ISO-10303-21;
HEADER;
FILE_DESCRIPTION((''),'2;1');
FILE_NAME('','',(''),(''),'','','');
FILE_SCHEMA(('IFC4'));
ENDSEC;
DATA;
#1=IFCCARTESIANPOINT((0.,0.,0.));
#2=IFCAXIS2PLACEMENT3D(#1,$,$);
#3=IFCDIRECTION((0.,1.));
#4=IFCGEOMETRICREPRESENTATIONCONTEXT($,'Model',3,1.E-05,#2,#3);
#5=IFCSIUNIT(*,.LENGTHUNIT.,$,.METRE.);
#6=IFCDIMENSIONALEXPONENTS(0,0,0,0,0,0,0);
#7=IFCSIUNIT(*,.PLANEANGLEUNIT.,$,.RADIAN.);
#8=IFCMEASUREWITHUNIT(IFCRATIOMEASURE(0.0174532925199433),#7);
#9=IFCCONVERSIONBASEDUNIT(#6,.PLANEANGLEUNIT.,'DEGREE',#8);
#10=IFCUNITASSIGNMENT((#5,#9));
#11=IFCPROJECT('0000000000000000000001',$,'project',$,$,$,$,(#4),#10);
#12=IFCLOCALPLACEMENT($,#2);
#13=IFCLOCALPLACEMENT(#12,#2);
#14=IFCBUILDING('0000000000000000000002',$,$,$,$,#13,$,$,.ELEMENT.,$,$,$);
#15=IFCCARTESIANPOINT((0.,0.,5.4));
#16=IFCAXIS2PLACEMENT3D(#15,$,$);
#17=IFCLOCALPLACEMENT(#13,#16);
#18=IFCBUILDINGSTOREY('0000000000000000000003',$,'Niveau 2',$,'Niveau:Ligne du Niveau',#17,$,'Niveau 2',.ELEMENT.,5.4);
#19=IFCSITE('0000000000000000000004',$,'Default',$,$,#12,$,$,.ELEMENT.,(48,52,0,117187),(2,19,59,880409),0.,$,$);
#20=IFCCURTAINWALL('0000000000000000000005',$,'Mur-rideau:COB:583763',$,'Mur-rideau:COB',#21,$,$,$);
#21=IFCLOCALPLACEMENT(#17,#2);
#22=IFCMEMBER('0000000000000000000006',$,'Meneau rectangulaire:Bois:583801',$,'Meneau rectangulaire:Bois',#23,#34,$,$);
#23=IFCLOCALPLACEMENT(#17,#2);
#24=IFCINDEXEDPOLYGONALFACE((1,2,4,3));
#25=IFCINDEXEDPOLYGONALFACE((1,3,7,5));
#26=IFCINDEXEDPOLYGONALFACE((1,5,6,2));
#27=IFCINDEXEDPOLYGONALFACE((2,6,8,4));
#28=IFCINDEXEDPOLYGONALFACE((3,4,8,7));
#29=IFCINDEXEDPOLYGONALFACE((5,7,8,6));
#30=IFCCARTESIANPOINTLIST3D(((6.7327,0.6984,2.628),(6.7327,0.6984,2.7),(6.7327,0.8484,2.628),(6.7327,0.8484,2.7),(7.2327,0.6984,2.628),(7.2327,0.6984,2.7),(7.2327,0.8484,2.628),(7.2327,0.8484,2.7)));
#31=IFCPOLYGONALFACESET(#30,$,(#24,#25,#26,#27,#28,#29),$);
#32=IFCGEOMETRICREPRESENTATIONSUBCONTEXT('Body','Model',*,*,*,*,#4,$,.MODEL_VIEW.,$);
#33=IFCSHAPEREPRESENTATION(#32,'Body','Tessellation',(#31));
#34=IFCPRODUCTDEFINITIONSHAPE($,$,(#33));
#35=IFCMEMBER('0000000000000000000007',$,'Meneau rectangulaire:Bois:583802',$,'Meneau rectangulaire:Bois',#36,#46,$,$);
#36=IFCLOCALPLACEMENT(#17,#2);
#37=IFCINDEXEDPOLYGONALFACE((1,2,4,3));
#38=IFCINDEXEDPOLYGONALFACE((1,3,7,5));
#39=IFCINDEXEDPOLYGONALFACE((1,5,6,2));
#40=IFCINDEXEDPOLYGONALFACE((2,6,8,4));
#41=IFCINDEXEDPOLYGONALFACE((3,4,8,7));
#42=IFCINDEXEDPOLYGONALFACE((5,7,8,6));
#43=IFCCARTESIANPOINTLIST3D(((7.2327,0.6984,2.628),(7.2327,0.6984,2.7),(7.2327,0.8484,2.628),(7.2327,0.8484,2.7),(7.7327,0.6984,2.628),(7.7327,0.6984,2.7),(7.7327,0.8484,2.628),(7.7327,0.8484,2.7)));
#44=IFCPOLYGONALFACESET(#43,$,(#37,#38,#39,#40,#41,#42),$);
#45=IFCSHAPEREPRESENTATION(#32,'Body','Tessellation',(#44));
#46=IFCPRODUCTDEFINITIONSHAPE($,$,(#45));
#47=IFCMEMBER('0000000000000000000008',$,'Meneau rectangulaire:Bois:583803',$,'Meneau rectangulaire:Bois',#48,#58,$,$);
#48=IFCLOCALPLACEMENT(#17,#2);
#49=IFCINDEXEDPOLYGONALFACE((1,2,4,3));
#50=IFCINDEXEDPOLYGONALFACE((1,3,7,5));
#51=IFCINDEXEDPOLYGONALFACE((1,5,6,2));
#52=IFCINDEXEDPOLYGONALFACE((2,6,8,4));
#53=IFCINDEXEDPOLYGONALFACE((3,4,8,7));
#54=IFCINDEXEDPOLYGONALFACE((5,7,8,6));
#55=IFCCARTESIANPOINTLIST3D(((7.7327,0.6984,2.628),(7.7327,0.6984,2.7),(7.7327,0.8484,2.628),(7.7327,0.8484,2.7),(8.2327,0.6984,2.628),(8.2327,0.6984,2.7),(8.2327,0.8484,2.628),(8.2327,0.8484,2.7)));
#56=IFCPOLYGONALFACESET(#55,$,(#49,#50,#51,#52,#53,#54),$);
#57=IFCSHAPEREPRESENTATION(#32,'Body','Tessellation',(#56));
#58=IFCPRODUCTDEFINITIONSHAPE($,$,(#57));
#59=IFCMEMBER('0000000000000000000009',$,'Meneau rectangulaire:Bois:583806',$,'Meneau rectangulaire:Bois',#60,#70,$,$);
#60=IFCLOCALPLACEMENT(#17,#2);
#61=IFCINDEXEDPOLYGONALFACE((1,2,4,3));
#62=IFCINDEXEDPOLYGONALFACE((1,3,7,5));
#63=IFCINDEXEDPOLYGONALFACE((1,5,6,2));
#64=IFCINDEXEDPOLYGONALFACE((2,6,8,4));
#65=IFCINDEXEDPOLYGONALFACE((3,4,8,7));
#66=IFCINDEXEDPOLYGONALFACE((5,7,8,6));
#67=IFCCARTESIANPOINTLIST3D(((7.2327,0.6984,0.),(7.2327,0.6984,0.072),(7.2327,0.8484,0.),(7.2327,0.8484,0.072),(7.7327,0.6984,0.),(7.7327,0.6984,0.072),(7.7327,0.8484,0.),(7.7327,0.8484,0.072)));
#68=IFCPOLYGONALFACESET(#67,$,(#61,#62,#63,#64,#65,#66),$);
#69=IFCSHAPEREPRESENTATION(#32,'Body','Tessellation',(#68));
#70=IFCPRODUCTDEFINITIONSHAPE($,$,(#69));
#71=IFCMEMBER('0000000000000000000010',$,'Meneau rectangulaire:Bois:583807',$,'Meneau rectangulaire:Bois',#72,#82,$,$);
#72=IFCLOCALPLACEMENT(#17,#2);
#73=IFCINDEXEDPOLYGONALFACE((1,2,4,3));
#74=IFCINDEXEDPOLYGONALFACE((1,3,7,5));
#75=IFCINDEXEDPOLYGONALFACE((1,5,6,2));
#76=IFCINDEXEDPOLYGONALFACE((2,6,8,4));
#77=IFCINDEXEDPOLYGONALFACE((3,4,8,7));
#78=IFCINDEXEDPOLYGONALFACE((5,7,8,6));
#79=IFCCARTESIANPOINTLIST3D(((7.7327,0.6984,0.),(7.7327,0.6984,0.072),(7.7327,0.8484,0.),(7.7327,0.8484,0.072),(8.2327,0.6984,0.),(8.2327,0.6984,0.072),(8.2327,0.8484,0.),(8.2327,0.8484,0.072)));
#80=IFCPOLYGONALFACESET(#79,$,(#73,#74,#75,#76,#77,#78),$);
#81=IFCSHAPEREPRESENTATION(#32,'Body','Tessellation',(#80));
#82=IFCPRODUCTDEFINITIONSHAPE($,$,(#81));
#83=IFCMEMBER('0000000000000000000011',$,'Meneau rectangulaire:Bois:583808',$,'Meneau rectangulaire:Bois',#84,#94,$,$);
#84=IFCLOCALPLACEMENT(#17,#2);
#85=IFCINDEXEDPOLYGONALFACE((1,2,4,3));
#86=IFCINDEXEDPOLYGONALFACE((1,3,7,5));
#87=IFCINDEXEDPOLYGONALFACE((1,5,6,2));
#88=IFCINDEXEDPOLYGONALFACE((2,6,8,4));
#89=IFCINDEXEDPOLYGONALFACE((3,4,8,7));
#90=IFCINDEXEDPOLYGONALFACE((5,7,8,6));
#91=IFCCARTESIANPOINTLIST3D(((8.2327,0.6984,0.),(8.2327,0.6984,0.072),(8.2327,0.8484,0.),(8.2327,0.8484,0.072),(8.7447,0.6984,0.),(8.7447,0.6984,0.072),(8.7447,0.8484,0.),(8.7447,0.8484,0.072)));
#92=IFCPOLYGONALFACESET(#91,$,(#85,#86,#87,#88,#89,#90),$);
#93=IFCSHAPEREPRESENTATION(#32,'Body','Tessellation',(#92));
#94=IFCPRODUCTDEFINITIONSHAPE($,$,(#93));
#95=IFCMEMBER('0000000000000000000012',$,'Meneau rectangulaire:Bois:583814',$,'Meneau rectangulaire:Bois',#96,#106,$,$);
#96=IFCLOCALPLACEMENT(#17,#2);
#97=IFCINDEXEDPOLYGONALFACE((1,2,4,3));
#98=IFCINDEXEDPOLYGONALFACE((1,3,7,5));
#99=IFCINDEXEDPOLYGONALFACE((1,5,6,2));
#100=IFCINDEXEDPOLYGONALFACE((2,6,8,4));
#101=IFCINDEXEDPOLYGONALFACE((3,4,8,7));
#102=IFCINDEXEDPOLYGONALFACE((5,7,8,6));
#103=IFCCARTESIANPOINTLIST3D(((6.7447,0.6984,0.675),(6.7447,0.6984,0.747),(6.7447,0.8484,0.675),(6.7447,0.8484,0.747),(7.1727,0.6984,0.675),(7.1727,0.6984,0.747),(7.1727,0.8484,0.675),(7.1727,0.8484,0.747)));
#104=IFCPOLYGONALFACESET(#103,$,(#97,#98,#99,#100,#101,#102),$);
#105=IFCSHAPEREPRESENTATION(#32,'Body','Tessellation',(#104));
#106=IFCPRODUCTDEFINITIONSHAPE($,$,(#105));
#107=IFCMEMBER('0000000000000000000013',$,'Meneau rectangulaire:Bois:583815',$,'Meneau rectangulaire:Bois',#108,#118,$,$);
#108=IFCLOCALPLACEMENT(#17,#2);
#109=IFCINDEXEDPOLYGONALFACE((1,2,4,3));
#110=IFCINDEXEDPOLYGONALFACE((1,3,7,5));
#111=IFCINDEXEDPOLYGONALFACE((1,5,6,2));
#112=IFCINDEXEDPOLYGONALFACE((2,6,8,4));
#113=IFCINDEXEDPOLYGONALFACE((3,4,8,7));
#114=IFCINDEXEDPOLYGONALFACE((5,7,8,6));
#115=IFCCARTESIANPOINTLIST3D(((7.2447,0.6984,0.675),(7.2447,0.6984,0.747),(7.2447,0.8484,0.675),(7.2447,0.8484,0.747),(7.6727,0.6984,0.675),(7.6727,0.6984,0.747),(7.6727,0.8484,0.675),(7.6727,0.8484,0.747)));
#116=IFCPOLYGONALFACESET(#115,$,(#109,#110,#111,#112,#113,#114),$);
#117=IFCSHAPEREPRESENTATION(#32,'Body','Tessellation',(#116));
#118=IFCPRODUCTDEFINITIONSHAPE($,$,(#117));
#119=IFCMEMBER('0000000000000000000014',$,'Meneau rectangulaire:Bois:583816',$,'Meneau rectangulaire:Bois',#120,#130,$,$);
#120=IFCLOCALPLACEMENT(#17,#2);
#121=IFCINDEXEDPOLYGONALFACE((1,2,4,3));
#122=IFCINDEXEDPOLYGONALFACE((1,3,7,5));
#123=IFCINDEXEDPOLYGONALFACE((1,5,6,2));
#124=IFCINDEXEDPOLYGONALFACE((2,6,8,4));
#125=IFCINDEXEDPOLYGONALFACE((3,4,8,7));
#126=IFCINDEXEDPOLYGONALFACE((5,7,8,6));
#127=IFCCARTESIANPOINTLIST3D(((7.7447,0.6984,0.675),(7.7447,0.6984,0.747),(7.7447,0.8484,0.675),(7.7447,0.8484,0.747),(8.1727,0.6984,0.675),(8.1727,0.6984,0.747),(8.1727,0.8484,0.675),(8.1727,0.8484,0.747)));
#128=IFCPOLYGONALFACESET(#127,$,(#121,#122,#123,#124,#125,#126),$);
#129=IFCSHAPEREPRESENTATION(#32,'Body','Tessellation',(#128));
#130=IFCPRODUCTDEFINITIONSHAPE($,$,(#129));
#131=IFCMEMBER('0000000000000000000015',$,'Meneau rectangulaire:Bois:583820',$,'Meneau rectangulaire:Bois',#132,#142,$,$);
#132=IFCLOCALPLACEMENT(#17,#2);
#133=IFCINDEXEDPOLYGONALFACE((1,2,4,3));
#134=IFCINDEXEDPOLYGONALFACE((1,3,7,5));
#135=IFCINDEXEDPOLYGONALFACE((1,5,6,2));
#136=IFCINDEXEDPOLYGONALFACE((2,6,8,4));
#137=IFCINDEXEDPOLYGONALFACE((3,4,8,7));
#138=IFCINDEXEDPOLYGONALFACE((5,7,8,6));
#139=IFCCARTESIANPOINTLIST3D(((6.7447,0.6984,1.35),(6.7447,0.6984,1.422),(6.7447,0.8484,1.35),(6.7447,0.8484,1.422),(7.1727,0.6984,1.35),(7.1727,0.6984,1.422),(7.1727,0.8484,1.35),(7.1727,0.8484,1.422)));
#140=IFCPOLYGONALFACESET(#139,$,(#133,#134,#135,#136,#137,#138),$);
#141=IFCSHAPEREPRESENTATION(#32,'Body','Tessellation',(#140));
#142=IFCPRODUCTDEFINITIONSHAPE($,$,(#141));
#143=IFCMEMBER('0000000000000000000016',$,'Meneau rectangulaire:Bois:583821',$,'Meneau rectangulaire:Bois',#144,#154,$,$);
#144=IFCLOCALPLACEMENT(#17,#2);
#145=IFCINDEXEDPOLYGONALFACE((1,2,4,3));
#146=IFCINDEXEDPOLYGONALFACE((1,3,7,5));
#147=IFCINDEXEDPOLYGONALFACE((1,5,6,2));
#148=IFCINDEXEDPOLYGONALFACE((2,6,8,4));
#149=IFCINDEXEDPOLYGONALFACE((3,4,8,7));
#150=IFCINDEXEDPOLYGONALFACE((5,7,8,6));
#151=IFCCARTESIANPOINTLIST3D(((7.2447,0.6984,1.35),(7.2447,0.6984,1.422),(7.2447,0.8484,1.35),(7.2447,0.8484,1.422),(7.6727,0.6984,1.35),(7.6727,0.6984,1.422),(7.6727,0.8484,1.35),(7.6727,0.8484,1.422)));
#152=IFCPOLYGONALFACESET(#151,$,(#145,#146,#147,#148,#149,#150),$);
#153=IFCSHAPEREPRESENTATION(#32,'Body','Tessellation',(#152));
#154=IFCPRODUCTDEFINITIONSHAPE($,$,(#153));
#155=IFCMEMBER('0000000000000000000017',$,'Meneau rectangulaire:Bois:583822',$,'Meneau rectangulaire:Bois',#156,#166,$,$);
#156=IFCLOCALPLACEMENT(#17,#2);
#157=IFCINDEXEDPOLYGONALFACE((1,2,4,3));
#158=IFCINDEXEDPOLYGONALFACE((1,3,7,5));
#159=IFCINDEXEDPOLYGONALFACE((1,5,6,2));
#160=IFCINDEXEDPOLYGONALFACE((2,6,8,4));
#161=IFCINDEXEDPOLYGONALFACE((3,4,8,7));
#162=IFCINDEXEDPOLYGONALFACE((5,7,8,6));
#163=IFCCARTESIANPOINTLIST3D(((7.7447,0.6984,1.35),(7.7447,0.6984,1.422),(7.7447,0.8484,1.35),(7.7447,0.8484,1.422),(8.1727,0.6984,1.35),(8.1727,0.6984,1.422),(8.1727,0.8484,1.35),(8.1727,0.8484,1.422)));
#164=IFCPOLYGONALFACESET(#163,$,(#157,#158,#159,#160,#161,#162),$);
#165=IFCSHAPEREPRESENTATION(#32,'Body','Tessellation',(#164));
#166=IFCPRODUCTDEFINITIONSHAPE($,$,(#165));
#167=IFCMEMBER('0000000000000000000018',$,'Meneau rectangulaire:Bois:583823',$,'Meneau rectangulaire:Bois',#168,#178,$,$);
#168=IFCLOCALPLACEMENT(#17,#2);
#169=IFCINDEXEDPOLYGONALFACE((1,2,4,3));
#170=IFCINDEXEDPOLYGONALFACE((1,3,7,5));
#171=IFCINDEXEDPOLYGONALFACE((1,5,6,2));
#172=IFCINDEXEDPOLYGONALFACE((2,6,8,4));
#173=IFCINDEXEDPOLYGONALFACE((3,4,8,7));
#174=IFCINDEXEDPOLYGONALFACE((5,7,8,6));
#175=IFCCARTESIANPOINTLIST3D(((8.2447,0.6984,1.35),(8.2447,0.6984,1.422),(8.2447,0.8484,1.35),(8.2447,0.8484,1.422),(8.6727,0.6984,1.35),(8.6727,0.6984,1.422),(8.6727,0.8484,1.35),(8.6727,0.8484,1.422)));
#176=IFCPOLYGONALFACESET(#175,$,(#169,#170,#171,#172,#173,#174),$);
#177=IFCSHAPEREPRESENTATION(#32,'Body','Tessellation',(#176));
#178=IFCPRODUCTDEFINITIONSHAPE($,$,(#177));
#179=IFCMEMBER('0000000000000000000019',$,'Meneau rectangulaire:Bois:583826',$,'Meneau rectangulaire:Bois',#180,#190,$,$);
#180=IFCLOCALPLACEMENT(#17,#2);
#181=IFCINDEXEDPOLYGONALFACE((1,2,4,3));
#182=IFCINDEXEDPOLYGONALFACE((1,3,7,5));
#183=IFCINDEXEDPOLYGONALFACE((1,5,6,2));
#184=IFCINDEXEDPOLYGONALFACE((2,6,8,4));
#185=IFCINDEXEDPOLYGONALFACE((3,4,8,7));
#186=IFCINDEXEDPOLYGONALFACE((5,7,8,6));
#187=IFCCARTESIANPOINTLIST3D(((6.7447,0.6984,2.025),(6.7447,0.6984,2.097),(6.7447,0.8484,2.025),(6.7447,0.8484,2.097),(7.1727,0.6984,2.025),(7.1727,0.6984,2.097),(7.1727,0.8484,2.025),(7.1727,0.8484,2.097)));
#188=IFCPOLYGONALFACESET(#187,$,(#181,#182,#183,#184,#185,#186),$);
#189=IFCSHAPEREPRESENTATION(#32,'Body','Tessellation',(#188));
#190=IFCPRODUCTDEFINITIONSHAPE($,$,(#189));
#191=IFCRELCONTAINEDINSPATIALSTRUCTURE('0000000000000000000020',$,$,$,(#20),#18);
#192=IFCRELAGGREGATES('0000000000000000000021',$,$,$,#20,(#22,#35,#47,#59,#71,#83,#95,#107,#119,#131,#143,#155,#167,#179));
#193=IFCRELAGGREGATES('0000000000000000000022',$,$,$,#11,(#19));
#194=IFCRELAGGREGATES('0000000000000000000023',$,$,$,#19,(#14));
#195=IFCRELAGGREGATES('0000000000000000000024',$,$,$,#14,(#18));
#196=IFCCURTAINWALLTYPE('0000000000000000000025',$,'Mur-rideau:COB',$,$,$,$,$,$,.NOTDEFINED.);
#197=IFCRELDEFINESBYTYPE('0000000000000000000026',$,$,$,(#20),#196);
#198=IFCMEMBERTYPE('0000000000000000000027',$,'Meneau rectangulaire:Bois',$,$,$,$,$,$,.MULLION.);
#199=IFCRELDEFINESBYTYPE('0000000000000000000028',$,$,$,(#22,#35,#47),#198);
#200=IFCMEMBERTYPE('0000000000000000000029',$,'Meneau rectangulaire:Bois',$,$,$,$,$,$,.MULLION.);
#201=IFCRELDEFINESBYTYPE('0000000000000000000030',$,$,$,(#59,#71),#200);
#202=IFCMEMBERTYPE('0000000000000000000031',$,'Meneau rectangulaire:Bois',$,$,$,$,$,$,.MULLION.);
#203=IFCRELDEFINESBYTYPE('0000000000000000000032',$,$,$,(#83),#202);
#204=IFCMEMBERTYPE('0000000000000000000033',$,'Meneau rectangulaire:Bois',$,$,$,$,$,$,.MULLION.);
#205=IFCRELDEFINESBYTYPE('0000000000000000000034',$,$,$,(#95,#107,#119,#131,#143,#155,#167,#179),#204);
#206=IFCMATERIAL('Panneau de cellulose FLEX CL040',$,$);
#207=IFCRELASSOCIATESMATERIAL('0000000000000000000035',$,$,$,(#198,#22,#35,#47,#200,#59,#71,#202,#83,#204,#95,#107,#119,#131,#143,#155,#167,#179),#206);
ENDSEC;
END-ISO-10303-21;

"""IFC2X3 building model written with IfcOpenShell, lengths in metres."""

from ifc_helpers import new_model, entity, si_unit, converted_unit, direction, frame, origin, origin_2d_with_axis, place, context, subcontext, project, spatial, rectangle, extrude, source, transform, mapped, material, type_object, type_shapes, element, aggregate, save


model = new_model("IFC2X3")

# Units and contexts
model_context = context("Model", 3, precision=1e-05, world=origin(), true_north=direction((0.0, 1.0)))
body_context = subcontext(model_context, "Body", "Model", "MODEL_VIEW")
ifc_project = project(units=[si_unit("LENGTHUNIT", "METRE"), converted_unit("PLANEANGLEUNIT", "DEGREE", entity("IfcRatioMeasure", 0.0174532925199433), si_unit("PLANEANGLEUNIT", "RADIAN"), dimensions=[0, 0, 0, 0, 0, 0, 0])], contexts=[model_context])

# Site, building, storey
site_placement = place(None, origin())
site = spatial("IfcSite", under=ifc_project, at=site_placement, Name="Default", CompositionType="ELEMENT", RefLatitude=(48, 52, 0, 117187), RefLongitude=(2, 19, 59, 880409), RefElevation=0.0)
building_placement = place(site_placement, origin())
building = spatial("IfcBuilding", under=site, at=building_placement, CompositionType="ELEMENT")
storey_placement = place(building_placement, frame((0.0, 0.0, 5.4)))
storey = spatial("IfcBuildingStorey", under=building, at=storey_placement, Name="Niveau 2", ObjectType="Niveau:Ligne du Niveau", LongName="Niveau 2", CompositionType="ELEMENT", Elevation=5.4)

# Curtain wall, members
curtain_wall_type_1 = type_object("IfcCurtainWallType", Name="Mur-rideau:COB", PredefinedType="NOTDEFINED")
curtain_wall_1_placement = place(storey_placement, frame((0.0, 0.0, -5.4)))
curtain_wall_1 = element("IfcCurtainWall", 1, at=curtain_wall_1_placement, inside=storey, type_object=curtain_wall_type_1, Name="Mur-rideau:COB:583763", ObjectType="Mur-rideau:COB")
ifc_material_1 = material(Name="Panneau de cellulose FLEX CL040")
member_type_1 = type_object("IfcMemberType", Name="Meneau rectangulaire:Bois", PredefinedType="MULLION", material=ifc_material_1)
shared_shape_1 = source(origin(), body_context, "Body", "SweptSolid", [
    extrude(rectangle(XDim=0.15, YDim=0.072, at=origin_2d_with_axis()), frame((-0.036, 0.0, -0.5), z_axis=(0.0, 0.0, 1.0), x_axis=(0.0, -1.0, 0.0)), (0.0, 0.0, 1.0), 0.5),
])
type_shapes(member_type_1, [shared_shape_1])
member_1_placement = place(storey_placement, frame((7.2327, 0.7734, 2.7), z_axis=(1.0, 0.0, 0.0), x_axis=(0.0, 0.0, 1.0)))
member_1 = element("IfcMember", 2, at=member_1_placement, type_object=member_type_1, material=ifc_material_1, Name="Meneau rectangulaire:Bois:583801", ObjectType="Meneau rectangulaire:Bois", context=body_context, shape_type="MappedRepresentation", body=[
    mapped(shared_shape_1, transform((0.0, 0.0, 0.0), scale=1.0)),
])
member_2_placement = place(storey_placement, frame((7.7327, 0.7734, 2.7), z_axis=(1.0, 0.0, 0.0), x_axis=(0.0, 0.0, 1.0)))
member_2 = element("IfcMember", 3, at=member_2_placement, type_object=member_type_1, material=ifc_material_1, Name="Meneau rectangulaire:Bois:583802", ObjectType="Meneau rectangulaire:Bois", context=body_context, shape_type="MappedRepresentation", body=[
    mapped(shared_shape_1, transform((0.0, 0.0, 0.0), scale=1.0)),
])
member_3_placement = place(storey_placement, frame((8.2327, 0.7734, 2.7), z_axis=(1.0, 0.0, 0.0), x_axis=(0.0, 0.0, 1.0)))
member_3 = element("IfcMember", 4, at=member_3_placement, type_object=member_type_1, material=ifc_material_1, Name="Meneau rectangulaire:Bois:583803", ObjectType="Meneau rectangulaire:Bois", context=body_context, shape_type="MappedRepresentation", body=[
    mapped(shared_shape_1, transform((0.0, 0.0, 0.0), scale=1.0)),
])
member_type_2 = type_object("IfcMemberType", Name="Meneau rectangulaire:Bois", PredefinedType="MULLION", material=ifc_material_1)
shared_shape_2 = source(origin(), body_context, "Body", "SweptSolid", [
    extrude(rectangle(XDim=0.15, YDim=0.072, at=origin_2d_with_axis()), frame((-0.036, 0.0, -0.5), z_axis=(0.0, 0.0, 1.0), x_axis=(0.0, -1.0, 0.0)), (0.0, 0.0, 1.0), 0.5),
])
type_shapes(member_type_2, [shared_shape_2])
member_4_placement = place(storey_placement, frame((7.2327, 0.7734, 0.0), z_axis=(-1.0, 0.0, 0.0), x_axis=(0.0, 0.0, -1.0)))
member_4 = element("IfcMember", 5, at=member_4_placement, type_object=member_type_2, material=ifc_material_1, Name="Meneau rectangulaire:Bois:583806", ObjectType="Meneau rectangulaire:Bois", context=body_context, shape_type="MappedRepresentation", body=[
    mapped(shared_shape_2, transform((0.0, 0.0, 0.0), scale=1.0)),
])
member_5_placement = place(storey_placement, frame((7.7327, 0.7734, 0.0), z_axis=(-1.0, 0.0, 0.0), x_axis=(0.0, 0.0, -1.0)))
member_5 = element("IfcMember", 6, at=member_5_placement, type_object=member_type_2, material=ifc_material_1, Name="Meneau rectangulaire:Bois:583807", ObjectType="Meneau rectangulaire:Bois", context=body_context, shape_type="MappedRepresentation", body=[
    mapped(shared_shape_2, transform((0.0, 0.0, 0.0), scale=1.0)),
])
member_type_3 = type_object("IfcMemberType", Name="Meneau rectangulaire:Bois", PredefinedType="MULLION", material=ifc_material_1)
shared_shape_3 = source(origin(), body_context, "Body", "SweptSolid", [
    extrude(rectangle(XDim=0.15, YDim=0.072, at=origin_2d_with_axis()), frame((-0.036, 0.0, -0.512), z_axis=(0.0, 0.0, 1.0), x_axis=(0.0, -1.0, 0.0)), (0.0, 0.0, 1.0), 0.512),
])
type_shapes(member_type_3, [shared_shape_3])
member_6_placement = place(storey_placement, frame((8.2327, 0.7734, 0.0), z_axis=(-1.0, 0.0, 0.0), x_axis=(0.0, 0.0, -1.0)))
member_6 = element("IfcMember", 7, at=member_6_placement, type_object=member_type_3, material=ifc_material_1, Name="Meneau rectangulaire:Bois:583808", ObjectType="Meneau rectangulaire:Bois", context=body_context, shape_type="MappedRepresentation", body=[
    mapped(shared_shape_3, transform((0.0, 0.0, 0.0), scale=1.0)),
])
member_type_4 = type_object("IfcMemberType", Name="Meneau rectangulaire:Bois", PredefinedType="MULLION", material=ifc_material_1)
shared_shape_4 = source(origin(), body_context, "Body", "SweptSolid", [
    extrude(rectangle(XDim=0.15, YDim=0.072, at=origin_2d_with_axis()), frame((-0.024, 0.0, -0.428), z_axis=(0.0, 0.0, 1.0), x_axis=(0.0, -1.0, 0.0)), (0.0, 0.0, 1.0), 0.428),
])
type_shapes(member_type_4, [shared_shape_4])
member_7_placement = place(storey_placement, frame((7.1727, 0.7734, 0.735), z_axis=(1.0, 0.0, 0.0), x_axis=(0.0, 0.0, 1.0)))
member_7 = element("IfcMember", 8, at=member_7_placement, type_object=member_type_4, material=ifc_material_1, Name="Meneau rectangulaire:Bois:583814", ObjectType="Meneau rectangulaire:Bois", context=body_context, shape_type="MappedRepresentation", body=[
    mapped(shared_shape_4, transform((0.0, 0.0, 0.0), scale=1.0)),
])
member_8_placement = place(storey_placement, frame((7.6727, 0.7734, 0.735), z_axis=(1.0, 0.0, 0.0), x_axis=(0.0, 0.0, 1.0)))
member_8 = element("IfcMember", 9, at=member_8_placement, type_object=member_type_4, material=ifc_material_1, Name="Meneau rectangulaire:Bois:583815", ObjectType="Meneau rectangulaire:Bois", context=body_context, shape_type="MappedRepresentation", body=[
    mapped(shared_shape_4, transform((0.0, 0.0, 0.0), scale=1.0)),
])
member_9_placement = place(storey_placement, frame((8.1727, 0.7734, 0.735), z_axis=(1.0, 0.0, 0.0), x_axis=(0.0, 0.0, 1.0)))
member_9 = element("IfcMember", 10, at=member_9_placement, type_object=member_type_4, material=ifc_material_1, Name="Meneau rectangulaire:Bois:583816", ObjectType="Meneau rectangulaire:Bois", context=body_context, shape_type="MappedRepresentation", body=[
    mapped(shared_shape_4, transform((0.0, 0.0, 0.0), scale=1.0)),
])
member_10_placement = place(storey_placement, frame((7.1727, 0.7734, 1.41), z_axis=(1.0, 0.0, 0.0), x_axis=(0.0, 0.0, 1.0)))
member_10 = element("IfcMember", 11, at=member_10_placement, type_object=member_type_4, material=ifc_material_1, Name="Meneau rectangulaire:Bois:583820", ObjectType="Meneau rectangulaire:Bois", context=body_context, shape_type="MappedRepresentation", body=[
    mapped(shared_shape_4, transform((0.0, 0.0, 0.0), scale=1.0)),
])
member_11_placement = place(storey_placement, frame((7.6727, 0.7734, 1.41), z_axis=(1.0, 0.0, 0.0), x_axis=(0.0, 0.0, 1.0)))
member_11 = element("IfcMember", 12, at=member_11_placement, type_object=member_type_4, material=ifc_material_1, Name="Meneau rectangulaire:Bois:583821", ObjectType="Meneau rectangulaire:Bois", context=body_context, shape_type="MappedRepresentation", body=[
    mapped(shared_shape_4, transform((0.0, 0.0, 0.0), scale=1.0)),
])
member_12_placement = place(storey_placement, frame((8.1727, 0.7734, 1.41), z_axis=(1.0, 0.0, 0.0), x_axis=(0.0, 0.0, 1.0)))
member_12 = element("IfcMember", 13, at=member_12_placement, type_object=member_type_4, material=ifc_material_1, Name="Meneau rectangulaire:Bois:583822", ObjectType="Meneau rectangulaire:Bois", context=body_context, shape_type="MappedRepresentation", body=[
    mapped(shared_shape_4, transform((0.0, 0.0, 0.0), scale=1.0)),
])
member_13_placement = place(storey_placement, frame((8.6727, 0.7734, 1.41), z_axis=(1.0, 0.0, 0.0), x_axis=(0.0, 0.0, 1.0)))
member_13 = element("IfcMember", 14, at=member_13_placement, type_object=member_type_4, material=ifc_material_1, Name="Meneau rectangulaire:Bois:583823", ObjectType="Meneau rectangulaire:Bois", context=body_context, shape_type="MappedRepresentation", body=[
    mapped(shared_shape_4, transform((0.0, 0.0, 0.0), scale=1.0)),
])
member_14_placement = place(storey_placement, frame((7.1727, 0.7734, 2.085), z_axis=(1.0, 0.0, 0.0), x_axis=(0.0, 0.0, 1.0)))
member_14 = element("IfcMember", 15, at=member_14_placement, type_object=member_type_4, material=ifc_material_1, Name="Meneau rectangulaire:Bois:583826", ObjectType="Meneau rectangulaire:Bois", context=body_context, shape_type="MappedRepresentation", body=[
    mapped(shared_shape_4, transform((0.0, 0.0, 0.0), scale=1.0)),
])
aggregate(curtain_wall_1, [member_1, member_2, member_3, member_4, member_5, member_6, member_7, member_8, member_9, member_10, member_11, member_12, member_13, member_14])

save(model, "model.ifc")
